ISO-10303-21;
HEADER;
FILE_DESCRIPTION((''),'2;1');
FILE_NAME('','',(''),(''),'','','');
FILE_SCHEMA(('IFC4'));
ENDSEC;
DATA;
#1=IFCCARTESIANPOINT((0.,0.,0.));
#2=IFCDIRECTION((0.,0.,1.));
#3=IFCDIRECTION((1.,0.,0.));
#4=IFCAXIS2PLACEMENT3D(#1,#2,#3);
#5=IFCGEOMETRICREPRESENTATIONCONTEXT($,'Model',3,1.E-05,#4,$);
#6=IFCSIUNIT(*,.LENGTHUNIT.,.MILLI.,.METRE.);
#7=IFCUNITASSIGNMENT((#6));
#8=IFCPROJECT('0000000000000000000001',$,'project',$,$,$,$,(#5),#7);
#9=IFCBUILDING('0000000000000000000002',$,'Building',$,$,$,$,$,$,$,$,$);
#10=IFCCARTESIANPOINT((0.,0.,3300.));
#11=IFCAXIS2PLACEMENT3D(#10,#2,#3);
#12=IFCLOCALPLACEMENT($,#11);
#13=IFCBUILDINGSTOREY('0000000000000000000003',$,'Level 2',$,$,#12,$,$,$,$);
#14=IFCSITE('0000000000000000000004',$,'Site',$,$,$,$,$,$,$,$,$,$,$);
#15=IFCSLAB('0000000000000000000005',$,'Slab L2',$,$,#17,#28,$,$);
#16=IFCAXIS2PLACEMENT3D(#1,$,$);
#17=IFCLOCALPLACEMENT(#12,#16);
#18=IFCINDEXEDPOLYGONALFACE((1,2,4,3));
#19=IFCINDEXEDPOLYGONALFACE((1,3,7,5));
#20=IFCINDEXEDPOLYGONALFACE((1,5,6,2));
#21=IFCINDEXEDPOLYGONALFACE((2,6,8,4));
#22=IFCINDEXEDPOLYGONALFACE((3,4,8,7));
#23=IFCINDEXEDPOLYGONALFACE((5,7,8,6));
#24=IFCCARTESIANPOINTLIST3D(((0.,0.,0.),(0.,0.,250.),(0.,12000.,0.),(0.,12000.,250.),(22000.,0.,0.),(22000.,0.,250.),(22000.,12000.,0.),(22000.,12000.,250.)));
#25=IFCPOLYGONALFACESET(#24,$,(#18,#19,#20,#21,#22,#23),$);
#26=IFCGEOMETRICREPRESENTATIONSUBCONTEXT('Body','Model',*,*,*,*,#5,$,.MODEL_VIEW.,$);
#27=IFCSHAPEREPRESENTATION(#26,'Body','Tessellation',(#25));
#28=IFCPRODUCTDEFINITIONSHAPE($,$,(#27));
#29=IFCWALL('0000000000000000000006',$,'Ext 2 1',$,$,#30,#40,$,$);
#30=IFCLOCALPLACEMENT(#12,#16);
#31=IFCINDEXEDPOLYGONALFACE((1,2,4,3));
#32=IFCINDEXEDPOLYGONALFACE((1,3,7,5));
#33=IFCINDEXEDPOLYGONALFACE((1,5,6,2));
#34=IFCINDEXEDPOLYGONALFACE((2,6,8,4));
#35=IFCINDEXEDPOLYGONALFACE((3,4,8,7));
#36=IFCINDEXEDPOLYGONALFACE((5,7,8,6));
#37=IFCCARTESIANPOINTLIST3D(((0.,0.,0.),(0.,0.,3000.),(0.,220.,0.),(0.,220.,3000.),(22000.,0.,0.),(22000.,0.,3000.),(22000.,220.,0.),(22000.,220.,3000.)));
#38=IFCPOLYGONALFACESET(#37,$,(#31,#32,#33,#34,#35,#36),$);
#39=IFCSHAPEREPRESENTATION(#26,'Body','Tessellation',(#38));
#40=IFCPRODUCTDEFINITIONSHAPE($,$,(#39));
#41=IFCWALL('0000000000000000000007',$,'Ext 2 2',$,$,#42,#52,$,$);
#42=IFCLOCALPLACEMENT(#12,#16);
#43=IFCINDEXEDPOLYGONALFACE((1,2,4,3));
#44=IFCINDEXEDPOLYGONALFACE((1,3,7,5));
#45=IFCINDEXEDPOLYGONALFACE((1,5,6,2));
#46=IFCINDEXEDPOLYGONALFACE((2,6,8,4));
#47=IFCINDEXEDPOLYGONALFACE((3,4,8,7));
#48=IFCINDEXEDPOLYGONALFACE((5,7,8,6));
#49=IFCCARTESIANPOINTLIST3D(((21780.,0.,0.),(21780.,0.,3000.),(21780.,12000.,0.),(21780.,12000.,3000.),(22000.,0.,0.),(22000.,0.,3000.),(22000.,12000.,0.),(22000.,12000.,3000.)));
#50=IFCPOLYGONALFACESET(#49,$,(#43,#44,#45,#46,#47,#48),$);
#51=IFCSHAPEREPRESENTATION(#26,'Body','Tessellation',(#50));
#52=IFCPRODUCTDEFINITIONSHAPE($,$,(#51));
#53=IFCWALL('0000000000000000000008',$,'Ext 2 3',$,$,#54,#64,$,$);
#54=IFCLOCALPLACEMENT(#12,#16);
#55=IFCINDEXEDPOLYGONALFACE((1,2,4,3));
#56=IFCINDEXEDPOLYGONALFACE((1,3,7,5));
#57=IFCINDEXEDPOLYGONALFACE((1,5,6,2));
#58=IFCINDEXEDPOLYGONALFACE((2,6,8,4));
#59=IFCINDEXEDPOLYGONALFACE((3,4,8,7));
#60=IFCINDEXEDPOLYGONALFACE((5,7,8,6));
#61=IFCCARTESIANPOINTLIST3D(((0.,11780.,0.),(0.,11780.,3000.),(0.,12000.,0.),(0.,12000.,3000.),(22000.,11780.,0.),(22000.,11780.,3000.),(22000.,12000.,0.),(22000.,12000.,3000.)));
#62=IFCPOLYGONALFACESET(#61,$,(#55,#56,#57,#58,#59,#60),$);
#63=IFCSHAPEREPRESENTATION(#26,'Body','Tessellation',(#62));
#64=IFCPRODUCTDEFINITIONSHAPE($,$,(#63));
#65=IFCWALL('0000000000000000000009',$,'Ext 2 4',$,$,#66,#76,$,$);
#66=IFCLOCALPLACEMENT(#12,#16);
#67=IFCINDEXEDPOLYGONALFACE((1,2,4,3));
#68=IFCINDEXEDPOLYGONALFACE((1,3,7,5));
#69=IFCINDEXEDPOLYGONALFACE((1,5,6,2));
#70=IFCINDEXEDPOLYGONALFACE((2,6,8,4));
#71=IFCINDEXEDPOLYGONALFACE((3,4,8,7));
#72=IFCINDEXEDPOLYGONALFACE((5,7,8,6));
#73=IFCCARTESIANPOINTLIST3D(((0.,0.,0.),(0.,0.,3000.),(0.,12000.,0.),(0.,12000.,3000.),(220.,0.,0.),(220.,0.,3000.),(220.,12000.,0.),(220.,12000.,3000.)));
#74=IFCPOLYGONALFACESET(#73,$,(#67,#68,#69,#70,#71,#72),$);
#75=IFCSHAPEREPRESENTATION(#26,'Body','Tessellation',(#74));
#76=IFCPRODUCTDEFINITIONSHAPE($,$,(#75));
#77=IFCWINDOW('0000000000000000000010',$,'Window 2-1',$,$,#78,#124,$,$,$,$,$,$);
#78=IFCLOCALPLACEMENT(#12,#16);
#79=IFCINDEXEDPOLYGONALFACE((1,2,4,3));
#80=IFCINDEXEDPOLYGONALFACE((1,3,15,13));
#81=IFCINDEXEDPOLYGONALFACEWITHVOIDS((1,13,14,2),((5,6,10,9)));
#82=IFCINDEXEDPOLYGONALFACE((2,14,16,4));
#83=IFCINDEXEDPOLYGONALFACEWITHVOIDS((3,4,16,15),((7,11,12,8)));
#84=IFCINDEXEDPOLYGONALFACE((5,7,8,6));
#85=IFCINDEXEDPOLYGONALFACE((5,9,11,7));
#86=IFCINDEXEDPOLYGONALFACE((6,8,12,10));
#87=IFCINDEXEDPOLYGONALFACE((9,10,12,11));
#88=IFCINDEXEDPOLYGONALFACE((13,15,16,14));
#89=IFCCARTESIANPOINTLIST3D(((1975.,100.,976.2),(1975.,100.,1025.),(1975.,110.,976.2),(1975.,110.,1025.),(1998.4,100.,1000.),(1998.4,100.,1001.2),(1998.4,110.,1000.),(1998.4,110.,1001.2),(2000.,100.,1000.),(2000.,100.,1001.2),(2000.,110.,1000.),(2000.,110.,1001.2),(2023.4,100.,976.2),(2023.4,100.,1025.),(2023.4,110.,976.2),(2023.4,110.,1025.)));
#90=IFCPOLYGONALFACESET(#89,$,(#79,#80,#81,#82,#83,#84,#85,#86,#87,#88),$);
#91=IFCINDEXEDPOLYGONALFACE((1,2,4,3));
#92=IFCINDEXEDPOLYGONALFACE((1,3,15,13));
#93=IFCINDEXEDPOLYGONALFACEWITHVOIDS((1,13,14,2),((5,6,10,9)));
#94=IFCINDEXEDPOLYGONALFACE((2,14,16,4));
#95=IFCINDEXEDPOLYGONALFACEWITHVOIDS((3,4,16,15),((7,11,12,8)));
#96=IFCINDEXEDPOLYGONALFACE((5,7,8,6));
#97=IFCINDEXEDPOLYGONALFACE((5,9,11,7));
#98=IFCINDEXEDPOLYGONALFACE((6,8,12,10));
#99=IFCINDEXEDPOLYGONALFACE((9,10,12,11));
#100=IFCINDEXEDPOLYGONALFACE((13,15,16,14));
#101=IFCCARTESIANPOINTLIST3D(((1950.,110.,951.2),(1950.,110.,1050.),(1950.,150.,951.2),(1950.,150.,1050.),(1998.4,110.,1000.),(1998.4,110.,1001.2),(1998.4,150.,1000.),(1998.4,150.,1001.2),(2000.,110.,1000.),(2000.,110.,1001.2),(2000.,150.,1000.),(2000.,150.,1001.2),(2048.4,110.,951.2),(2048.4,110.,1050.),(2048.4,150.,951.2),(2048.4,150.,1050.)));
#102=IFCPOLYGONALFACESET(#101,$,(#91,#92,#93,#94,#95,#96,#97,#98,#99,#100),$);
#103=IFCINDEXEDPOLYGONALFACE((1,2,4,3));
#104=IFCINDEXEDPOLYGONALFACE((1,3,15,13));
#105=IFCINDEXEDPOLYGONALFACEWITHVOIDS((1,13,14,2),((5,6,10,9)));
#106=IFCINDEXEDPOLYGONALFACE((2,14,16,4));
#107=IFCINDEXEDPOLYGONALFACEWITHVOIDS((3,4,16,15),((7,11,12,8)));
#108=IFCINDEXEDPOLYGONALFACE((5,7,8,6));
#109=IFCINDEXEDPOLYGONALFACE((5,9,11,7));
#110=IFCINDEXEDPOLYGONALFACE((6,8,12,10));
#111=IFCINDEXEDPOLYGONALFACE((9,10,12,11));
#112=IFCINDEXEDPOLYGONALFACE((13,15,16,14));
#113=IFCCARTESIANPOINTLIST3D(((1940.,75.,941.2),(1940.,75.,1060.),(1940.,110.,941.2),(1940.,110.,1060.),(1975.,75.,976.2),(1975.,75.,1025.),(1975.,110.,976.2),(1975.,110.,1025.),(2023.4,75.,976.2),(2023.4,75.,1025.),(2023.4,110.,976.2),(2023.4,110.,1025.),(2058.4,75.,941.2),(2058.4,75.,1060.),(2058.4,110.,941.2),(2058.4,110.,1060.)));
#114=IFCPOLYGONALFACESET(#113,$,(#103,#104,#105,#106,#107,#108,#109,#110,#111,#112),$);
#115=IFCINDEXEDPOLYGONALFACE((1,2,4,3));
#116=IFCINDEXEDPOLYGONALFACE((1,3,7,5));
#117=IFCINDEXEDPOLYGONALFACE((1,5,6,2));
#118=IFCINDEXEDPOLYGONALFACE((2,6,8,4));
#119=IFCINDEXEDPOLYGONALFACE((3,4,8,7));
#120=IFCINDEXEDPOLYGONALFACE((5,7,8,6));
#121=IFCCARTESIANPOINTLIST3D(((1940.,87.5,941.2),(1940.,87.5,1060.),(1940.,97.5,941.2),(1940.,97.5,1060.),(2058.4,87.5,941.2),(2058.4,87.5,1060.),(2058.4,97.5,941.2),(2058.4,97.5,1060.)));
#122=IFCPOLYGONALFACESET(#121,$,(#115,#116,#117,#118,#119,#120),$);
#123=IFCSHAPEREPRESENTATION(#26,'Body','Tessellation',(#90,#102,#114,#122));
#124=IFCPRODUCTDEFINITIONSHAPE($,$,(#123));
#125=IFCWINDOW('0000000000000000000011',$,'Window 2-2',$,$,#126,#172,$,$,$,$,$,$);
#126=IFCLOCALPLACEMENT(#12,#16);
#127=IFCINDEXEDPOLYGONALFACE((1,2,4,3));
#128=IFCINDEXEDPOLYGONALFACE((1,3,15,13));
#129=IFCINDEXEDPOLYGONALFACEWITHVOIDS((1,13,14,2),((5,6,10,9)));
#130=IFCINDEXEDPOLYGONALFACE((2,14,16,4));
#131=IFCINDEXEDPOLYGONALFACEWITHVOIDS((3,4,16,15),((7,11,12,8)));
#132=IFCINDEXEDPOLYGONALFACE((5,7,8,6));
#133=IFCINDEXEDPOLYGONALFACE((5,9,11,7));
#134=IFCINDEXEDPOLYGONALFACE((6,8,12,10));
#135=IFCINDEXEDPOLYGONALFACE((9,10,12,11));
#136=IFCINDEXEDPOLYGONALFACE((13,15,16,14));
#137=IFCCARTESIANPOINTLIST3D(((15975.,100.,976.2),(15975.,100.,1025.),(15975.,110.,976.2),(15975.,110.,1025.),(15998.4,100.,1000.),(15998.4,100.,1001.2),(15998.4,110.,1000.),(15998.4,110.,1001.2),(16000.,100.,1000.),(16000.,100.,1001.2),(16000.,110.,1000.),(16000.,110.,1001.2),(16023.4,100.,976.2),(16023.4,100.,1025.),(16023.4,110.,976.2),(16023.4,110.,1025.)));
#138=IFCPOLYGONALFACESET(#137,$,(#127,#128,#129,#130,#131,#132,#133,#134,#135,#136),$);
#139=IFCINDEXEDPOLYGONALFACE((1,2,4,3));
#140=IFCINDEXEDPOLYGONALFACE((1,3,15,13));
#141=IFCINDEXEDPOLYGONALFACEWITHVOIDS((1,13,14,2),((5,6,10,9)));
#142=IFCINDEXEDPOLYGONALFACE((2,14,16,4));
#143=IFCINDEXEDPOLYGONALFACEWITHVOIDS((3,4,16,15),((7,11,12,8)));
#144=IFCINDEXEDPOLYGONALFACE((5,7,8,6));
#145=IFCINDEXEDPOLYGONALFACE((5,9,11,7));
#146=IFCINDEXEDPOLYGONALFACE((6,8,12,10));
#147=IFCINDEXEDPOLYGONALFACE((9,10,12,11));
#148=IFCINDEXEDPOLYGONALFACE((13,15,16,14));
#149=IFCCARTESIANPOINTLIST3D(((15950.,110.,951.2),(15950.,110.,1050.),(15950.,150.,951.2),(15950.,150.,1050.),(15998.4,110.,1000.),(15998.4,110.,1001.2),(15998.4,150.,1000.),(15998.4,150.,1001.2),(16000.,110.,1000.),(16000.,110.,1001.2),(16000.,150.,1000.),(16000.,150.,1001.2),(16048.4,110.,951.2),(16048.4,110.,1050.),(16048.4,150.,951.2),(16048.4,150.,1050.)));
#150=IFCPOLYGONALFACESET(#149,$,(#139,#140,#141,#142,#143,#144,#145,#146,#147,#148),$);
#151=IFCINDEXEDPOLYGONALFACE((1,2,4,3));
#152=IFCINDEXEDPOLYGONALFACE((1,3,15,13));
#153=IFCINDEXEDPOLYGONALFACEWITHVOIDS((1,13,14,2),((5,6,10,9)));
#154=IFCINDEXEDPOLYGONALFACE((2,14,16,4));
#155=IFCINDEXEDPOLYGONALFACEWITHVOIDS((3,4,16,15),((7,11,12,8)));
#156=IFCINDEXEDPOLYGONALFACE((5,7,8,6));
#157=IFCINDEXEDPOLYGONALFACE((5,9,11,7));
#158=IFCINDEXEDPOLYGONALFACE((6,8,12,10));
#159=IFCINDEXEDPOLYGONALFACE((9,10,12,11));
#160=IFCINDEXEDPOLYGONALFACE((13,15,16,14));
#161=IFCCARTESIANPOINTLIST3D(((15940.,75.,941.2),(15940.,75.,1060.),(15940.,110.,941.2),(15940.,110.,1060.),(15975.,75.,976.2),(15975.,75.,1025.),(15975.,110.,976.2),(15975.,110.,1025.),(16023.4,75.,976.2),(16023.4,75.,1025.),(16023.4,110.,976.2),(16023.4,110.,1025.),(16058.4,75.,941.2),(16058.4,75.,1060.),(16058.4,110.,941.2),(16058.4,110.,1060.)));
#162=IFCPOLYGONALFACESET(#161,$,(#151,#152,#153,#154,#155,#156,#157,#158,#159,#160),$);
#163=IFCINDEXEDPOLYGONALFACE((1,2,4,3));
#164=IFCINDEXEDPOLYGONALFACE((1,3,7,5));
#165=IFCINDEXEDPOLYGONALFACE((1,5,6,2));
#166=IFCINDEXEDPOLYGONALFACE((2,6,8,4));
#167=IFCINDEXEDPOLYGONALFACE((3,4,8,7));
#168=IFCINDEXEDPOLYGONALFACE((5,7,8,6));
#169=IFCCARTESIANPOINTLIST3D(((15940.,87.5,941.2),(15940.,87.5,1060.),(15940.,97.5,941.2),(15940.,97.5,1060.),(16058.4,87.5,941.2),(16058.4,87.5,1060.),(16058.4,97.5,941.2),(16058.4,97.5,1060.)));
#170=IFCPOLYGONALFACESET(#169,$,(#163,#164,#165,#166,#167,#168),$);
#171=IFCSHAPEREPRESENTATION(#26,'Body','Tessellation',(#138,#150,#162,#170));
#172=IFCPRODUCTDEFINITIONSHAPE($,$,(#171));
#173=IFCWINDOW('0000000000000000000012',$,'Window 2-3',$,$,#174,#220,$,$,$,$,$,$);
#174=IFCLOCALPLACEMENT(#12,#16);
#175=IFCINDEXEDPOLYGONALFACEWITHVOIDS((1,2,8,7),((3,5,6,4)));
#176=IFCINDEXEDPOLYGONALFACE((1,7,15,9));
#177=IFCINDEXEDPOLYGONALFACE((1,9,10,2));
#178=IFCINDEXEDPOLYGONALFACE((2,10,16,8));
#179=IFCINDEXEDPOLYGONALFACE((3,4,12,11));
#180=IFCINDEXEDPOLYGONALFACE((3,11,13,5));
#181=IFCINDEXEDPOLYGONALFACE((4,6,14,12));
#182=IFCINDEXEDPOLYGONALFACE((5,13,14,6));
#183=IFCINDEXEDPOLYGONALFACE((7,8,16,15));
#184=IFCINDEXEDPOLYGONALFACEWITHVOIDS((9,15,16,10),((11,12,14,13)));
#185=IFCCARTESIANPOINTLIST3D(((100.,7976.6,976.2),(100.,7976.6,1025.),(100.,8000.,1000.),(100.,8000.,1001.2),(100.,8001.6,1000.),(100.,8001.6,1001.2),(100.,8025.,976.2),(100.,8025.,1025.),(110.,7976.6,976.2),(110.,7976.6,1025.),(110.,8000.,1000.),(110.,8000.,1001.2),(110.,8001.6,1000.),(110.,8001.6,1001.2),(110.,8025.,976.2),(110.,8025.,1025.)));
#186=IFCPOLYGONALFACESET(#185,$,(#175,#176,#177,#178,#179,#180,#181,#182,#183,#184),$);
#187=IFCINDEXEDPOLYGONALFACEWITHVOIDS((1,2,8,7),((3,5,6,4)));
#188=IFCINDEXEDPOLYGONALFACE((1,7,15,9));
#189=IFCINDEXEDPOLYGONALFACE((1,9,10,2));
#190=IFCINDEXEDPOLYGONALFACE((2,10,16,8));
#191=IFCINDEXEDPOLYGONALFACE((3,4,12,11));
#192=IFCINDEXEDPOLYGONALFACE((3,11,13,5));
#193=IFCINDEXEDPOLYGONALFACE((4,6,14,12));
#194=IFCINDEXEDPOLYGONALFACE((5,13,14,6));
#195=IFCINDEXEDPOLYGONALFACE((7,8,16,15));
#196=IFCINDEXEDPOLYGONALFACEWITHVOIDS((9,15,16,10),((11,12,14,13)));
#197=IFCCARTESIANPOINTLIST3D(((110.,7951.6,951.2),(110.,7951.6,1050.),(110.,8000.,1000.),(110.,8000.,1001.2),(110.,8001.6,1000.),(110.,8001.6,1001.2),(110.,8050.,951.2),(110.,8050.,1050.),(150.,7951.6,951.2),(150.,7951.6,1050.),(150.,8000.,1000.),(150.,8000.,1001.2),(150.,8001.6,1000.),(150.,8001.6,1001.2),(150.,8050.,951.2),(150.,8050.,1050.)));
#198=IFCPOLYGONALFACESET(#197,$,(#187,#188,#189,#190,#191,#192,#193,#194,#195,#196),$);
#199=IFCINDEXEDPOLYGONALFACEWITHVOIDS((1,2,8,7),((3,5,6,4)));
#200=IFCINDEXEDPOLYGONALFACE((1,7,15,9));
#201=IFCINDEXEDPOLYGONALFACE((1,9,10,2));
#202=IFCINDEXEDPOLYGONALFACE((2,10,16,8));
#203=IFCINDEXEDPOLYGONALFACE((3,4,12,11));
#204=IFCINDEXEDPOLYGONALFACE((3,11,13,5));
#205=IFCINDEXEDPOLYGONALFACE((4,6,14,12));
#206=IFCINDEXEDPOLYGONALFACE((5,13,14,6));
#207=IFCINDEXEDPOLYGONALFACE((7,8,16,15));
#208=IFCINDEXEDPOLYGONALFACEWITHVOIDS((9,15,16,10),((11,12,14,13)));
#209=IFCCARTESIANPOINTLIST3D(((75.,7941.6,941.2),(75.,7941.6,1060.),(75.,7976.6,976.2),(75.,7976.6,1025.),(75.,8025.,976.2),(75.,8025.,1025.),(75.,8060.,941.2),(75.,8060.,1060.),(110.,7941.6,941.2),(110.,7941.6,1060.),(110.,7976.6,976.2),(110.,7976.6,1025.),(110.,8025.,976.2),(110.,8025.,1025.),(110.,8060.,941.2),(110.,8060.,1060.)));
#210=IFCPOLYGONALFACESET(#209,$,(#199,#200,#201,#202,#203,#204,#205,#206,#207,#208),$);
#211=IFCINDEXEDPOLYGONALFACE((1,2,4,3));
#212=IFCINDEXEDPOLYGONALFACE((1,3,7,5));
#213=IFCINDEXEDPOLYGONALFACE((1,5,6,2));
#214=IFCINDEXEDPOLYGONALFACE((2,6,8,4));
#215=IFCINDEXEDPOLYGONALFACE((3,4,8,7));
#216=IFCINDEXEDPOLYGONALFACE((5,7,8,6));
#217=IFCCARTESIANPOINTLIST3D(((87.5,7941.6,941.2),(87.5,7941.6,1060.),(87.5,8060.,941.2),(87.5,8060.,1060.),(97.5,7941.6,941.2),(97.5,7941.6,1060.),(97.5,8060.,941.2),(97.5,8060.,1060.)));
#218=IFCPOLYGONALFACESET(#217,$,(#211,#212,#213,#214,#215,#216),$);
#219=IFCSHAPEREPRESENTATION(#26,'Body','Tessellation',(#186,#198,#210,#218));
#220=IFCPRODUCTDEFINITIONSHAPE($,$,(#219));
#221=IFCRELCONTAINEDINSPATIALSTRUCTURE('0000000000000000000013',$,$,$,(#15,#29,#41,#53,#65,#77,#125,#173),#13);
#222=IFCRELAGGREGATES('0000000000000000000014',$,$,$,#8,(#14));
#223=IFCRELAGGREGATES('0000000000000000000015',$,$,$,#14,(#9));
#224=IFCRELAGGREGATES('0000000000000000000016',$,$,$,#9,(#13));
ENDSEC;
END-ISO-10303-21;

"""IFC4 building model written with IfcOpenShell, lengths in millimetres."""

from ifc_helpers import new_model, si_unit, frame, origin_with_axes, place, context, subcontext, project, spatial, line, indexed_curve, outline, extrude, element, save


model = new_model("IFC4")

# Units and contexts
model_context = context("Model", 3, precision=1e-05, world=origin_with_axes())
body_context = subcontext(model_context, "Body", "Model", "MODEL_VIEW")
ifc_project = project(units=[si_unit("LENGTHUNIT", "METRE", prefix="MILLI")], contexts=[model_context])

# Site, building, storey
site = spatial("IfcSite", under=ifc_project, Name="Site")
building = spatial("IfcBuilding", under=site, Name="Building")
storey_placement = place(None, frame((0.0, 0.0, 3300.0), z_axis=(0.0, 0.0, 1.0), x_axis=(1.0, 0.0, 0.0)))
storey = spatial("IfcBuildingStorey", under=building, at=storey_placement, Name="Level 2")

# Slab
slab_placement = place(storey_placement, origin_with_axes())
element("IfcSlab", 1, at=slab_placement, inside=storey, Name="Slab L2", context=body_context, shape_type="SweptSolid", body=[
    extrude(outline(indexed_curve([(0.0, 0.0), (22000.0, 0.0), (22000.0, 12000.0), (0.0, 12000.0), (0.0, 0.0)])), None, (0.0, 0.0, 1.0), 250.0),
])

# Walls
wall_1_placement = place(storey_placement, origin_with_axes())
element("IfcWall", 2, at=wall_1_placement, inside=storey, Name="Ext 2 1", context=body_context, shape_type="SweptSolid", body=[
    extrude(outline(indexed_curve([(0.0, 0.0), (0.0, 220.0), (22000.0, 220.0), (22000.0, 0.0), (0.0, 0.0)], self_intersect=False)), origin_with_axes(), (0.0, 0.0, 1.0), 3000.0),
])
wall_2_placement = place(storey_placement, frame((22000.0, 0.0, 0.0), z_axis=(0.0, 0.0, 1.0), x_axis=(0.0, 1.0, 0.0)))
element("IfcWall", 3, at=wall_2_placement, inside=storey, Name="Ext 2 2", context=body_context, shape_type="SweptSolid", body=[
    extrude(outline(indexed_curve([(0.0, 0.0), (0.0, 220.0), (12000.0, 220.0), (12000.0, 0.0), (0.0, 0.0)], self_intersect=False)), origin_with_axes(), (0.0, 0.0, 1.0), 3000.0),
])
wall_3_placement = place(storey_placement, frame((22000.0, 12000.0, 0.0), z_axis=(0.0, 0.0, 1.0), x_axis=(-1.0, 0.0, 0.0)))
element("IfcWall", 4, at=wall_3_placement, inside=storey, Name="Ext 2 3", context=body_context, shape_type="SweptSolid", body=[
    extrude(outline(indexed_curve([(0.0, 0.0), (0.0, 220.0), (22000.0, 220.0), (22000.0, 0.0), (0.0, 0.0)], self_intersect=False)), origin_with_axes(), (0.0, 0.0, 1.0), 3000.0),
])
wall_4_placement = place(storey_placement, frame((0.0, 12000.0, 0.0), z_axis=(0.0, 0.0, 1.0), x_axis=(0.0, -1.0, 0.0)))
element("IfcWall", 5, at=wall_4_placement, inside=storey, Name="Ext 2 4", context=body_context, shape_type="SweptSolid", body=[
    extrude(outline(indexed_curve([(0.0, 0.0), (0.0, 220.0), (12000.0, 220.0), (12000.0, 0.0), (0.0, 0.0)], self_intersect=False)), origin_with_axes(), (0.0, 0.0, 1.0), 3000.0),
])

# Windows
for number, where, z_axis, x_axis, name in (
    (6, (2000.0, 200.0, 1000.0), (0.0, 0.0, 1.0), (-1.0, 0.0, 0.0), "Window 2-1"),
    (7, (16000.0, 200.0, 1000.0), (0.0, 0.0, 1.0), (-1.0, 0.0, 0.0), "Window 2-2"),
    (8, (200.0, 8000.0, 1000.0), (0.0, 0.0, 1.0), (0.0, 1.0, 0.0), "Window 2-3"),
):
    element("IfcWindow", number, at=place(storey_placement, frame(where, z_axis=z_axis, x_axis=x_axis)), inside=storey, Name=name, context=body_context, shape_type="SweptSolid", body=[
        extrude(outline(indexed_curve([(0.0, 0.0), (1.6, 0.0), (1.6, 1.2), (0.0, 1.2)], segments=[line(1, 2, 3, 4, 1)]), holes=[indexed_curve([(25.0, 25.0), (-23.4, 25.0), (-23.4, -23.8), (25.0, -23.8)], segments=[line(1, 2, 3, 4, 1)])]), frame((0.0, 90.0, 0.0), z_axis=(0.0, -1.0, 0.0), x_axis=(1.0, 0.0, 0.0)), (0.0, 0.0, -1.0), 10.0),
        extrude(outline(indexed_curve([(0.0, 0.0), (1.6, 0.0), (1.6, 1.2), (0.0, 1.2)], segments=[line(1, 2, 3, 4, 1)]), holes=[indexed_curve([(50.0, 50.0), (-48.4, 50.0), (-48.4, -48.8), (50.0, -48.8)], segments=[line(1, 2, 3, 4, 1)])]), frame((0.0, 50.0, 0.0), z_axis=(0.0, -1.0, 0.0), x_axis=(1.0, 0.0, 0.0)), (0.0, 0.0, -1.0), 40.0),
        extrude(outline(indexed_curve([(0.0, 0.0), (-48.4, 0.0), (-48.4, -48.8), (0.0, -48.8)], segments=[line(1, 2, 3, 4, 1)]), holes=[indexed_curve([(35.0, 35.0), (-83.4, 35.0), (-83.4, -83.8), (35.0, -83.8)], segments=[line(1, 2, 3, 4, 1)])]), frame((25.0, 90.0, 25.0), z_axis=(0.0, -1.0, 0.0), x_axis=(1.0, 0.0, 0.0)), (0.0, 0.0, -1.0), 35.0),
        extrude(outline(indexed_curve([(35.0, 35.0), (-83.4, 35.0), (-83.4, -83.8), (35.0, -83.8)], segments=[line(1, 2, 3, 4, 1)])), frame((25.0, 102.5, 25.0), z_axis=(0.0, -1.0, 0.0), x_axis=(1.0, 0.0, 0.0)), (0.0, 0.0, -1.0), 10.0),
    ])

save(model, "model.ifc")
